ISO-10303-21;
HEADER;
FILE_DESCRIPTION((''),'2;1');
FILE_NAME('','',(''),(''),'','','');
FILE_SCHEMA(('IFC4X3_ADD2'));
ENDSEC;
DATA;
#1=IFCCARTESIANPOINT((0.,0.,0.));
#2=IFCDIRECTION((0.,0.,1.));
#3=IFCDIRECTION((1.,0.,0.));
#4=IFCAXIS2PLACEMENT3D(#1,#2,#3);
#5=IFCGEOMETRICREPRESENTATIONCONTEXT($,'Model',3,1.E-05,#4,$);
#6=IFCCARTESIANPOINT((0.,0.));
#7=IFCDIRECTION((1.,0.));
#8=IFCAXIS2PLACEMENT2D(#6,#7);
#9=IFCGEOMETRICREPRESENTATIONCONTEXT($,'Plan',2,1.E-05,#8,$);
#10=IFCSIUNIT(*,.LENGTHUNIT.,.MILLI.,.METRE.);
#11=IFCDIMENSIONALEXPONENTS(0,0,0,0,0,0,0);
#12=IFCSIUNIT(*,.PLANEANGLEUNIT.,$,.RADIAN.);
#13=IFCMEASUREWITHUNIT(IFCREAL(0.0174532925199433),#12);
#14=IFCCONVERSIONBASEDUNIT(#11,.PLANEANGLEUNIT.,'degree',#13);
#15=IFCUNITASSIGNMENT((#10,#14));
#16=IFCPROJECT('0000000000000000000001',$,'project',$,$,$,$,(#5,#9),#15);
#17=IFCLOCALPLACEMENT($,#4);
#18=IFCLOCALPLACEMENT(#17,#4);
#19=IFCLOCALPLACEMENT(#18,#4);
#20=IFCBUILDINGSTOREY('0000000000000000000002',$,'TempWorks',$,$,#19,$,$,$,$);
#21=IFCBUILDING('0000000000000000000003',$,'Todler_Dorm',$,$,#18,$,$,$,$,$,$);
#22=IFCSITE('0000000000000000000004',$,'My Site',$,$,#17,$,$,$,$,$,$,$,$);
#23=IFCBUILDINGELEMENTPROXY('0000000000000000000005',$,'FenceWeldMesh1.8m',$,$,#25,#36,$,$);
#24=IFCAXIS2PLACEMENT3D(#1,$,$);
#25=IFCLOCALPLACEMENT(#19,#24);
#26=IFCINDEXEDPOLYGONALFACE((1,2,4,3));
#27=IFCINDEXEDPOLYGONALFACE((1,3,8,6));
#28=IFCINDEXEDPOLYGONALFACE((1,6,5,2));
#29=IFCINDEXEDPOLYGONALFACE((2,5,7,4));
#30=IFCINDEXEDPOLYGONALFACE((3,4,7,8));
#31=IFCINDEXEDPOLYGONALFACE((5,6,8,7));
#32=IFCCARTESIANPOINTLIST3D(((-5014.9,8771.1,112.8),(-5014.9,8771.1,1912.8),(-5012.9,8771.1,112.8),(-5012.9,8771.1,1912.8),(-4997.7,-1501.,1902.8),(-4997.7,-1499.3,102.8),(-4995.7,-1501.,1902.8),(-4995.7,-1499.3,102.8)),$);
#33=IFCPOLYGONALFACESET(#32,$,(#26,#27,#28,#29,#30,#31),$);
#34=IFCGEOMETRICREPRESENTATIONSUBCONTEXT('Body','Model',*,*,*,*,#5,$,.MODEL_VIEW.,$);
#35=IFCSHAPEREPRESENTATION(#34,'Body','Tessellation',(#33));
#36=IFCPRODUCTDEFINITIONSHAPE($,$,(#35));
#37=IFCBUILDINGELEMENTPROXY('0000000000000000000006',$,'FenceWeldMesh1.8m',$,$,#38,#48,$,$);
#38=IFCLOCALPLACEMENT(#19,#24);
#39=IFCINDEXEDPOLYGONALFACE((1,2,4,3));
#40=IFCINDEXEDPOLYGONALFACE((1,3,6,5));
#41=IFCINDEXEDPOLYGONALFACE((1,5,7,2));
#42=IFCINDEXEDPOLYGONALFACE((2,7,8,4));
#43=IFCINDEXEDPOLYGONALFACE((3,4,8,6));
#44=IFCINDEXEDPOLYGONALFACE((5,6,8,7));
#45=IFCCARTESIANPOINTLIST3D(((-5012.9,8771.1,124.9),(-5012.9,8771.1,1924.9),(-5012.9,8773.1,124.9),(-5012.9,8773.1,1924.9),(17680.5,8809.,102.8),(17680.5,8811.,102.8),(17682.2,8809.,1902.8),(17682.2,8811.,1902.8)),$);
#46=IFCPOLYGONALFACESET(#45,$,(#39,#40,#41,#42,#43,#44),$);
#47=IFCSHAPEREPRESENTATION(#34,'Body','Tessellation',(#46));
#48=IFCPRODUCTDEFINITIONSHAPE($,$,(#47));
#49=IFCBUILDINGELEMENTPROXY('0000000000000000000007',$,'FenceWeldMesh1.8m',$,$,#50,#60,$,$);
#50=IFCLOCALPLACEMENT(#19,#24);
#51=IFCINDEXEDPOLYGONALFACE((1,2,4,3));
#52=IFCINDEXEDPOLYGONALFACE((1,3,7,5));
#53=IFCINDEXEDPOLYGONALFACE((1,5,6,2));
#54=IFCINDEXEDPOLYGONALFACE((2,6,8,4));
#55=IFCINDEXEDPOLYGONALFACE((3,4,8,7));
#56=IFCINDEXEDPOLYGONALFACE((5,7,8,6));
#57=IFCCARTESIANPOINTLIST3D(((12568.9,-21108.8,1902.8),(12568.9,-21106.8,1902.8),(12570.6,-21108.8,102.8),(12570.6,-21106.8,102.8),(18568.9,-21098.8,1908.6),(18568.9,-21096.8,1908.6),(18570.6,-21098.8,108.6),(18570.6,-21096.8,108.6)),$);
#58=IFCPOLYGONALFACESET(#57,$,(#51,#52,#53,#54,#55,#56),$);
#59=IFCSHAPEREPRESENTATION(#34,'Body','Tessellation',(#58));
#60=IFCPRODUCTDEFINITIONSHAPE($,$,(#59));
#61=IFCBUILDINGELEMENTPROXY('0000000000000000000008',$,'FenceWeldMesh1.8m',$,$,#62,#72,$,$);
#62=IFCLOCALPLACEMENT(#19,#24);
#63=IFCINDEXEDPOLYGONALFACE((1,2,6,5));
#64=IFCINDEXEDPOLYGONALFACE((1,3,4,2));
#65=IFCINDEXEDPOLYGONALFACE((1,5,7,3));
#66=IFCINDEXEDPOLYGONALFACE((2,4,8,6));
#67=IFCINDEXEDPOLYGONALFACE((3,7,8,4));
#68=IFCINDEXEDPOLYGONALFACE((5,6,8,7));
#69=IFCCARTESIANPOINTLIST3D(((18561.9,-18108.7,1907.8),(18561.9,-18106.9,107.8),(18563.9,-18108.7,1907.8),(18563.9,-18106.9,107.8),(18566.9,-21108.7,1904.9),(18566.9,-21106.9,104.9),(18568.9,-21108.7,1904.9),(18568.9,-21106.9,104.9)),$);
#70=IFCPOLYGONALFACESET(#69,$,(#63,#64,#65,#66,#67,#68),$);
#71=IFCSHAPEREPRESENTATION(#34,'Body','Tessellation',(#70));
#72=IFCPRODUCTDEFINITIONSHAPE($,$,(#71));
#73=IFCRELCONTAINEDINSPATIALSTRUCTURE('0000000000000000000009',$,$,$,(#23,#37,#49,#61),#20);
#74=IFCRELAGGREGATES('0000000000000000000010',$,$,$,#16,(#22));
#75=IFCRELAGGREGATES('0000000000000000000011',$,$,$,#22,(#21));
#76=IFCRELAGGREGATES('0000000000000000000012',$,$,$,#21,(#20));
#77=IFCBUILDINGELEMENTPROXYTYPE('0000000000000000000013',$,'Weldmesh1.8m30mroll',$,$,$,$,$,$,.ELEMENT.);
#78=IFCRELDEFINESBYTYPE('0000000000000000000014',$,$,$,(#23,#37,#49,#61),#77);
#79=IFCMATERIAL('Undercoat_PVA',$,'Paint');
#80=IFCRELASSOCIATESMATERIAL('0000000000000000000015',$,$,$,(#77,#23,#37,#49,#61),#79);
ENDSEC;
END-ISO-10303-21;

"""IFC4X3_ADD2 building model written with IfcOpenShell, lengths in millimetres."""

from ifc_helpers import new_model, entity, si_unit, converted_unit, frame, origin_with_axes, origin_2d_with_axis, place, context, subcontext, project, spatial, rectangle, extrude, clip, halfspace, material, material_profile, profile_set, profile_usage, type_object, element, save


model = new_model("IFC4X3_ADD2")

# Units and contexts
model_context = context("Model", 3, precision=1e-05, world=origin_with_axes())
plan_context = context("Plan", 2, precision=1e-05, world=origin_2d_with_axis())
body_context = subcontext(model_context, "Body", "Model", "MODEL_VIEW")
ifc_project = project(units=[si_unit("LENGTHUNIT", "METRE", prefix="MILLI"), converted_unit("PLANEANGLEUNIT", "degree", entity("IfcReal", 0.0174532925199433), si_unit("PLANEANGLEUNIT", "RADIAN"), dimensions=[0, 0, 0, 0, 0, 0, 0])], contexts=[model_context, plan_context])

# Site, building, storey
site_placement = place(None, origin_with_axes())
site = spatial("IfcSite", under=ifc_project, at=site_placement, Name="My Site")
building_placement = place(site_placement, origin_with_axes())
building = spatial("IfcBuilding", under=site, at=building_placement, Name="Todler_Dorm")
storey_placement = place(building_placement, origin_with_axes())
storey = spatial("IfcBuildingStorey", under=building, at=storey_placement, Name="TempWorks")

# Building element proxies
ifc_material = material(Name="Undercoat_PVA", Category="Paint")
ifc_material_profile = material_profile(ifc_material, rectangle(XDim=1800.0, YDim=2.0))
ifc_profile_set = profile_set([ifc_material_profile])
ifc_profile_usage_1 = profile_usage(ifc_profile_set, cardinal=5)
building_element_proxy_type = type_object("IfcBuildingElementProxyType", Name="Weldmesh1.8m30mroll", PredefinedType="ELEMENT", material=ifc_profile_set)
proxy_1_placement = place(storey_placement, frame((-4996.7, -1500.2, 1002.8), z_axis=(-0.001669, 0.999998, 0.000974), x_axis=(0.0, -0.000974, 1.0)))
element("IfcBuildingElementProxy", 1, at=proxy_1_placement, inside=storey, type_object=building_element_proxy_type, material=ifc_profile_usage_1, Name="FenceWeldMesh1.8m", context=body_context, shape_type="Clipping", body=[
    clip(extrude(rectangle(XDim=1800.0, YDim=2.0), origin_with_axes(), (0.0, 0.0, 1.0), 12071.3), halfspace(frame((-10.0, 22695.2, 10271.3), z_axis=(-0.000973, 0.0, 1.0), x_axis=(-1.0, 0.0, -0.000973)), False)),
])
ifc_profile_usage_2 = profile_usage(ifc_profile_set, cardinal=5)
proxy_2_placement = place(storey_placement, frame((17681.4, 8810.0, 1002.8), z_axis=(-0.999998, -0.001669, 0.000974), x_axis=(0.000974, 0.0, 1.0)))
element("IfcBuildingElementProxy", 2, at=proxy_2_placement, inside=storey, type_object=building_element_proxy_type, material=ifc_profile_usage_2, Name="FenceWeldMesh1.8m", context=body_context, shape_type="Clipping", body=[
    clip(extrude(rectangle(XDim=1800.0, YDim=2.0), origin_with_axes(), (0.0, 0.0, 1.0), 24494.3), halfspace(frame((-22.1, -10272.3, 22694.2), z_axis=(-0.000976, 0.0, 1.0), x_axis=(-1.0, 0.0, -0.000976)), False)),
])
ifc_profile_usage_3 = profile_usage(ifc_profile_set, cardinal=5)
proxy_3_placement = place(storey_placement, frame((12569.8, -21107.8, 1002.8), z_axis=(0.999998, 0.001668, 0.000974), x_axis=(-0.000974, 0.0, 1.0)))
element("IfcBuildingElementProxy", 3, at=proxy_3_placement, inside=storey, type_object=building_element_proxy_type, material=ifc_profile_usage_3, Name="FenceWeldMesh1.8m", context=body_context, shape_type="SweptSolid", body=[
    extrude(rectangle(XDim=1800.0, YDim=2.0), origin_with_axes(), (0.0, 0.0, 1.0), 6000.0),
])
ifc_profile_usage_4 = profile_usage(ifc_profile_set, cardinal=5)
proxy_4_placement = place(storey_placement, frame((18567.9, -21107.8, 1004.9), z_axis=(-0.001669, 0.999998, 0.000974), x_axis=(0.0, -0.000974, 1.0)))
element("IfcBuildingElementProxy", 4, at=proxy_4_placement, inside=storey, type_object=building_element_proxy_type, material=ifc_profile_usage_4, Name="FenceWeldMesh1.8m", context=body_context, shape_type="SweptSolid", body=[
    extrude(rectangle(XDim=1800.0, YDim=2.0), origin_with_axes(), (0.0, 0.0, 1.0), 3000.0),
])

save(model, "model.ifc")
